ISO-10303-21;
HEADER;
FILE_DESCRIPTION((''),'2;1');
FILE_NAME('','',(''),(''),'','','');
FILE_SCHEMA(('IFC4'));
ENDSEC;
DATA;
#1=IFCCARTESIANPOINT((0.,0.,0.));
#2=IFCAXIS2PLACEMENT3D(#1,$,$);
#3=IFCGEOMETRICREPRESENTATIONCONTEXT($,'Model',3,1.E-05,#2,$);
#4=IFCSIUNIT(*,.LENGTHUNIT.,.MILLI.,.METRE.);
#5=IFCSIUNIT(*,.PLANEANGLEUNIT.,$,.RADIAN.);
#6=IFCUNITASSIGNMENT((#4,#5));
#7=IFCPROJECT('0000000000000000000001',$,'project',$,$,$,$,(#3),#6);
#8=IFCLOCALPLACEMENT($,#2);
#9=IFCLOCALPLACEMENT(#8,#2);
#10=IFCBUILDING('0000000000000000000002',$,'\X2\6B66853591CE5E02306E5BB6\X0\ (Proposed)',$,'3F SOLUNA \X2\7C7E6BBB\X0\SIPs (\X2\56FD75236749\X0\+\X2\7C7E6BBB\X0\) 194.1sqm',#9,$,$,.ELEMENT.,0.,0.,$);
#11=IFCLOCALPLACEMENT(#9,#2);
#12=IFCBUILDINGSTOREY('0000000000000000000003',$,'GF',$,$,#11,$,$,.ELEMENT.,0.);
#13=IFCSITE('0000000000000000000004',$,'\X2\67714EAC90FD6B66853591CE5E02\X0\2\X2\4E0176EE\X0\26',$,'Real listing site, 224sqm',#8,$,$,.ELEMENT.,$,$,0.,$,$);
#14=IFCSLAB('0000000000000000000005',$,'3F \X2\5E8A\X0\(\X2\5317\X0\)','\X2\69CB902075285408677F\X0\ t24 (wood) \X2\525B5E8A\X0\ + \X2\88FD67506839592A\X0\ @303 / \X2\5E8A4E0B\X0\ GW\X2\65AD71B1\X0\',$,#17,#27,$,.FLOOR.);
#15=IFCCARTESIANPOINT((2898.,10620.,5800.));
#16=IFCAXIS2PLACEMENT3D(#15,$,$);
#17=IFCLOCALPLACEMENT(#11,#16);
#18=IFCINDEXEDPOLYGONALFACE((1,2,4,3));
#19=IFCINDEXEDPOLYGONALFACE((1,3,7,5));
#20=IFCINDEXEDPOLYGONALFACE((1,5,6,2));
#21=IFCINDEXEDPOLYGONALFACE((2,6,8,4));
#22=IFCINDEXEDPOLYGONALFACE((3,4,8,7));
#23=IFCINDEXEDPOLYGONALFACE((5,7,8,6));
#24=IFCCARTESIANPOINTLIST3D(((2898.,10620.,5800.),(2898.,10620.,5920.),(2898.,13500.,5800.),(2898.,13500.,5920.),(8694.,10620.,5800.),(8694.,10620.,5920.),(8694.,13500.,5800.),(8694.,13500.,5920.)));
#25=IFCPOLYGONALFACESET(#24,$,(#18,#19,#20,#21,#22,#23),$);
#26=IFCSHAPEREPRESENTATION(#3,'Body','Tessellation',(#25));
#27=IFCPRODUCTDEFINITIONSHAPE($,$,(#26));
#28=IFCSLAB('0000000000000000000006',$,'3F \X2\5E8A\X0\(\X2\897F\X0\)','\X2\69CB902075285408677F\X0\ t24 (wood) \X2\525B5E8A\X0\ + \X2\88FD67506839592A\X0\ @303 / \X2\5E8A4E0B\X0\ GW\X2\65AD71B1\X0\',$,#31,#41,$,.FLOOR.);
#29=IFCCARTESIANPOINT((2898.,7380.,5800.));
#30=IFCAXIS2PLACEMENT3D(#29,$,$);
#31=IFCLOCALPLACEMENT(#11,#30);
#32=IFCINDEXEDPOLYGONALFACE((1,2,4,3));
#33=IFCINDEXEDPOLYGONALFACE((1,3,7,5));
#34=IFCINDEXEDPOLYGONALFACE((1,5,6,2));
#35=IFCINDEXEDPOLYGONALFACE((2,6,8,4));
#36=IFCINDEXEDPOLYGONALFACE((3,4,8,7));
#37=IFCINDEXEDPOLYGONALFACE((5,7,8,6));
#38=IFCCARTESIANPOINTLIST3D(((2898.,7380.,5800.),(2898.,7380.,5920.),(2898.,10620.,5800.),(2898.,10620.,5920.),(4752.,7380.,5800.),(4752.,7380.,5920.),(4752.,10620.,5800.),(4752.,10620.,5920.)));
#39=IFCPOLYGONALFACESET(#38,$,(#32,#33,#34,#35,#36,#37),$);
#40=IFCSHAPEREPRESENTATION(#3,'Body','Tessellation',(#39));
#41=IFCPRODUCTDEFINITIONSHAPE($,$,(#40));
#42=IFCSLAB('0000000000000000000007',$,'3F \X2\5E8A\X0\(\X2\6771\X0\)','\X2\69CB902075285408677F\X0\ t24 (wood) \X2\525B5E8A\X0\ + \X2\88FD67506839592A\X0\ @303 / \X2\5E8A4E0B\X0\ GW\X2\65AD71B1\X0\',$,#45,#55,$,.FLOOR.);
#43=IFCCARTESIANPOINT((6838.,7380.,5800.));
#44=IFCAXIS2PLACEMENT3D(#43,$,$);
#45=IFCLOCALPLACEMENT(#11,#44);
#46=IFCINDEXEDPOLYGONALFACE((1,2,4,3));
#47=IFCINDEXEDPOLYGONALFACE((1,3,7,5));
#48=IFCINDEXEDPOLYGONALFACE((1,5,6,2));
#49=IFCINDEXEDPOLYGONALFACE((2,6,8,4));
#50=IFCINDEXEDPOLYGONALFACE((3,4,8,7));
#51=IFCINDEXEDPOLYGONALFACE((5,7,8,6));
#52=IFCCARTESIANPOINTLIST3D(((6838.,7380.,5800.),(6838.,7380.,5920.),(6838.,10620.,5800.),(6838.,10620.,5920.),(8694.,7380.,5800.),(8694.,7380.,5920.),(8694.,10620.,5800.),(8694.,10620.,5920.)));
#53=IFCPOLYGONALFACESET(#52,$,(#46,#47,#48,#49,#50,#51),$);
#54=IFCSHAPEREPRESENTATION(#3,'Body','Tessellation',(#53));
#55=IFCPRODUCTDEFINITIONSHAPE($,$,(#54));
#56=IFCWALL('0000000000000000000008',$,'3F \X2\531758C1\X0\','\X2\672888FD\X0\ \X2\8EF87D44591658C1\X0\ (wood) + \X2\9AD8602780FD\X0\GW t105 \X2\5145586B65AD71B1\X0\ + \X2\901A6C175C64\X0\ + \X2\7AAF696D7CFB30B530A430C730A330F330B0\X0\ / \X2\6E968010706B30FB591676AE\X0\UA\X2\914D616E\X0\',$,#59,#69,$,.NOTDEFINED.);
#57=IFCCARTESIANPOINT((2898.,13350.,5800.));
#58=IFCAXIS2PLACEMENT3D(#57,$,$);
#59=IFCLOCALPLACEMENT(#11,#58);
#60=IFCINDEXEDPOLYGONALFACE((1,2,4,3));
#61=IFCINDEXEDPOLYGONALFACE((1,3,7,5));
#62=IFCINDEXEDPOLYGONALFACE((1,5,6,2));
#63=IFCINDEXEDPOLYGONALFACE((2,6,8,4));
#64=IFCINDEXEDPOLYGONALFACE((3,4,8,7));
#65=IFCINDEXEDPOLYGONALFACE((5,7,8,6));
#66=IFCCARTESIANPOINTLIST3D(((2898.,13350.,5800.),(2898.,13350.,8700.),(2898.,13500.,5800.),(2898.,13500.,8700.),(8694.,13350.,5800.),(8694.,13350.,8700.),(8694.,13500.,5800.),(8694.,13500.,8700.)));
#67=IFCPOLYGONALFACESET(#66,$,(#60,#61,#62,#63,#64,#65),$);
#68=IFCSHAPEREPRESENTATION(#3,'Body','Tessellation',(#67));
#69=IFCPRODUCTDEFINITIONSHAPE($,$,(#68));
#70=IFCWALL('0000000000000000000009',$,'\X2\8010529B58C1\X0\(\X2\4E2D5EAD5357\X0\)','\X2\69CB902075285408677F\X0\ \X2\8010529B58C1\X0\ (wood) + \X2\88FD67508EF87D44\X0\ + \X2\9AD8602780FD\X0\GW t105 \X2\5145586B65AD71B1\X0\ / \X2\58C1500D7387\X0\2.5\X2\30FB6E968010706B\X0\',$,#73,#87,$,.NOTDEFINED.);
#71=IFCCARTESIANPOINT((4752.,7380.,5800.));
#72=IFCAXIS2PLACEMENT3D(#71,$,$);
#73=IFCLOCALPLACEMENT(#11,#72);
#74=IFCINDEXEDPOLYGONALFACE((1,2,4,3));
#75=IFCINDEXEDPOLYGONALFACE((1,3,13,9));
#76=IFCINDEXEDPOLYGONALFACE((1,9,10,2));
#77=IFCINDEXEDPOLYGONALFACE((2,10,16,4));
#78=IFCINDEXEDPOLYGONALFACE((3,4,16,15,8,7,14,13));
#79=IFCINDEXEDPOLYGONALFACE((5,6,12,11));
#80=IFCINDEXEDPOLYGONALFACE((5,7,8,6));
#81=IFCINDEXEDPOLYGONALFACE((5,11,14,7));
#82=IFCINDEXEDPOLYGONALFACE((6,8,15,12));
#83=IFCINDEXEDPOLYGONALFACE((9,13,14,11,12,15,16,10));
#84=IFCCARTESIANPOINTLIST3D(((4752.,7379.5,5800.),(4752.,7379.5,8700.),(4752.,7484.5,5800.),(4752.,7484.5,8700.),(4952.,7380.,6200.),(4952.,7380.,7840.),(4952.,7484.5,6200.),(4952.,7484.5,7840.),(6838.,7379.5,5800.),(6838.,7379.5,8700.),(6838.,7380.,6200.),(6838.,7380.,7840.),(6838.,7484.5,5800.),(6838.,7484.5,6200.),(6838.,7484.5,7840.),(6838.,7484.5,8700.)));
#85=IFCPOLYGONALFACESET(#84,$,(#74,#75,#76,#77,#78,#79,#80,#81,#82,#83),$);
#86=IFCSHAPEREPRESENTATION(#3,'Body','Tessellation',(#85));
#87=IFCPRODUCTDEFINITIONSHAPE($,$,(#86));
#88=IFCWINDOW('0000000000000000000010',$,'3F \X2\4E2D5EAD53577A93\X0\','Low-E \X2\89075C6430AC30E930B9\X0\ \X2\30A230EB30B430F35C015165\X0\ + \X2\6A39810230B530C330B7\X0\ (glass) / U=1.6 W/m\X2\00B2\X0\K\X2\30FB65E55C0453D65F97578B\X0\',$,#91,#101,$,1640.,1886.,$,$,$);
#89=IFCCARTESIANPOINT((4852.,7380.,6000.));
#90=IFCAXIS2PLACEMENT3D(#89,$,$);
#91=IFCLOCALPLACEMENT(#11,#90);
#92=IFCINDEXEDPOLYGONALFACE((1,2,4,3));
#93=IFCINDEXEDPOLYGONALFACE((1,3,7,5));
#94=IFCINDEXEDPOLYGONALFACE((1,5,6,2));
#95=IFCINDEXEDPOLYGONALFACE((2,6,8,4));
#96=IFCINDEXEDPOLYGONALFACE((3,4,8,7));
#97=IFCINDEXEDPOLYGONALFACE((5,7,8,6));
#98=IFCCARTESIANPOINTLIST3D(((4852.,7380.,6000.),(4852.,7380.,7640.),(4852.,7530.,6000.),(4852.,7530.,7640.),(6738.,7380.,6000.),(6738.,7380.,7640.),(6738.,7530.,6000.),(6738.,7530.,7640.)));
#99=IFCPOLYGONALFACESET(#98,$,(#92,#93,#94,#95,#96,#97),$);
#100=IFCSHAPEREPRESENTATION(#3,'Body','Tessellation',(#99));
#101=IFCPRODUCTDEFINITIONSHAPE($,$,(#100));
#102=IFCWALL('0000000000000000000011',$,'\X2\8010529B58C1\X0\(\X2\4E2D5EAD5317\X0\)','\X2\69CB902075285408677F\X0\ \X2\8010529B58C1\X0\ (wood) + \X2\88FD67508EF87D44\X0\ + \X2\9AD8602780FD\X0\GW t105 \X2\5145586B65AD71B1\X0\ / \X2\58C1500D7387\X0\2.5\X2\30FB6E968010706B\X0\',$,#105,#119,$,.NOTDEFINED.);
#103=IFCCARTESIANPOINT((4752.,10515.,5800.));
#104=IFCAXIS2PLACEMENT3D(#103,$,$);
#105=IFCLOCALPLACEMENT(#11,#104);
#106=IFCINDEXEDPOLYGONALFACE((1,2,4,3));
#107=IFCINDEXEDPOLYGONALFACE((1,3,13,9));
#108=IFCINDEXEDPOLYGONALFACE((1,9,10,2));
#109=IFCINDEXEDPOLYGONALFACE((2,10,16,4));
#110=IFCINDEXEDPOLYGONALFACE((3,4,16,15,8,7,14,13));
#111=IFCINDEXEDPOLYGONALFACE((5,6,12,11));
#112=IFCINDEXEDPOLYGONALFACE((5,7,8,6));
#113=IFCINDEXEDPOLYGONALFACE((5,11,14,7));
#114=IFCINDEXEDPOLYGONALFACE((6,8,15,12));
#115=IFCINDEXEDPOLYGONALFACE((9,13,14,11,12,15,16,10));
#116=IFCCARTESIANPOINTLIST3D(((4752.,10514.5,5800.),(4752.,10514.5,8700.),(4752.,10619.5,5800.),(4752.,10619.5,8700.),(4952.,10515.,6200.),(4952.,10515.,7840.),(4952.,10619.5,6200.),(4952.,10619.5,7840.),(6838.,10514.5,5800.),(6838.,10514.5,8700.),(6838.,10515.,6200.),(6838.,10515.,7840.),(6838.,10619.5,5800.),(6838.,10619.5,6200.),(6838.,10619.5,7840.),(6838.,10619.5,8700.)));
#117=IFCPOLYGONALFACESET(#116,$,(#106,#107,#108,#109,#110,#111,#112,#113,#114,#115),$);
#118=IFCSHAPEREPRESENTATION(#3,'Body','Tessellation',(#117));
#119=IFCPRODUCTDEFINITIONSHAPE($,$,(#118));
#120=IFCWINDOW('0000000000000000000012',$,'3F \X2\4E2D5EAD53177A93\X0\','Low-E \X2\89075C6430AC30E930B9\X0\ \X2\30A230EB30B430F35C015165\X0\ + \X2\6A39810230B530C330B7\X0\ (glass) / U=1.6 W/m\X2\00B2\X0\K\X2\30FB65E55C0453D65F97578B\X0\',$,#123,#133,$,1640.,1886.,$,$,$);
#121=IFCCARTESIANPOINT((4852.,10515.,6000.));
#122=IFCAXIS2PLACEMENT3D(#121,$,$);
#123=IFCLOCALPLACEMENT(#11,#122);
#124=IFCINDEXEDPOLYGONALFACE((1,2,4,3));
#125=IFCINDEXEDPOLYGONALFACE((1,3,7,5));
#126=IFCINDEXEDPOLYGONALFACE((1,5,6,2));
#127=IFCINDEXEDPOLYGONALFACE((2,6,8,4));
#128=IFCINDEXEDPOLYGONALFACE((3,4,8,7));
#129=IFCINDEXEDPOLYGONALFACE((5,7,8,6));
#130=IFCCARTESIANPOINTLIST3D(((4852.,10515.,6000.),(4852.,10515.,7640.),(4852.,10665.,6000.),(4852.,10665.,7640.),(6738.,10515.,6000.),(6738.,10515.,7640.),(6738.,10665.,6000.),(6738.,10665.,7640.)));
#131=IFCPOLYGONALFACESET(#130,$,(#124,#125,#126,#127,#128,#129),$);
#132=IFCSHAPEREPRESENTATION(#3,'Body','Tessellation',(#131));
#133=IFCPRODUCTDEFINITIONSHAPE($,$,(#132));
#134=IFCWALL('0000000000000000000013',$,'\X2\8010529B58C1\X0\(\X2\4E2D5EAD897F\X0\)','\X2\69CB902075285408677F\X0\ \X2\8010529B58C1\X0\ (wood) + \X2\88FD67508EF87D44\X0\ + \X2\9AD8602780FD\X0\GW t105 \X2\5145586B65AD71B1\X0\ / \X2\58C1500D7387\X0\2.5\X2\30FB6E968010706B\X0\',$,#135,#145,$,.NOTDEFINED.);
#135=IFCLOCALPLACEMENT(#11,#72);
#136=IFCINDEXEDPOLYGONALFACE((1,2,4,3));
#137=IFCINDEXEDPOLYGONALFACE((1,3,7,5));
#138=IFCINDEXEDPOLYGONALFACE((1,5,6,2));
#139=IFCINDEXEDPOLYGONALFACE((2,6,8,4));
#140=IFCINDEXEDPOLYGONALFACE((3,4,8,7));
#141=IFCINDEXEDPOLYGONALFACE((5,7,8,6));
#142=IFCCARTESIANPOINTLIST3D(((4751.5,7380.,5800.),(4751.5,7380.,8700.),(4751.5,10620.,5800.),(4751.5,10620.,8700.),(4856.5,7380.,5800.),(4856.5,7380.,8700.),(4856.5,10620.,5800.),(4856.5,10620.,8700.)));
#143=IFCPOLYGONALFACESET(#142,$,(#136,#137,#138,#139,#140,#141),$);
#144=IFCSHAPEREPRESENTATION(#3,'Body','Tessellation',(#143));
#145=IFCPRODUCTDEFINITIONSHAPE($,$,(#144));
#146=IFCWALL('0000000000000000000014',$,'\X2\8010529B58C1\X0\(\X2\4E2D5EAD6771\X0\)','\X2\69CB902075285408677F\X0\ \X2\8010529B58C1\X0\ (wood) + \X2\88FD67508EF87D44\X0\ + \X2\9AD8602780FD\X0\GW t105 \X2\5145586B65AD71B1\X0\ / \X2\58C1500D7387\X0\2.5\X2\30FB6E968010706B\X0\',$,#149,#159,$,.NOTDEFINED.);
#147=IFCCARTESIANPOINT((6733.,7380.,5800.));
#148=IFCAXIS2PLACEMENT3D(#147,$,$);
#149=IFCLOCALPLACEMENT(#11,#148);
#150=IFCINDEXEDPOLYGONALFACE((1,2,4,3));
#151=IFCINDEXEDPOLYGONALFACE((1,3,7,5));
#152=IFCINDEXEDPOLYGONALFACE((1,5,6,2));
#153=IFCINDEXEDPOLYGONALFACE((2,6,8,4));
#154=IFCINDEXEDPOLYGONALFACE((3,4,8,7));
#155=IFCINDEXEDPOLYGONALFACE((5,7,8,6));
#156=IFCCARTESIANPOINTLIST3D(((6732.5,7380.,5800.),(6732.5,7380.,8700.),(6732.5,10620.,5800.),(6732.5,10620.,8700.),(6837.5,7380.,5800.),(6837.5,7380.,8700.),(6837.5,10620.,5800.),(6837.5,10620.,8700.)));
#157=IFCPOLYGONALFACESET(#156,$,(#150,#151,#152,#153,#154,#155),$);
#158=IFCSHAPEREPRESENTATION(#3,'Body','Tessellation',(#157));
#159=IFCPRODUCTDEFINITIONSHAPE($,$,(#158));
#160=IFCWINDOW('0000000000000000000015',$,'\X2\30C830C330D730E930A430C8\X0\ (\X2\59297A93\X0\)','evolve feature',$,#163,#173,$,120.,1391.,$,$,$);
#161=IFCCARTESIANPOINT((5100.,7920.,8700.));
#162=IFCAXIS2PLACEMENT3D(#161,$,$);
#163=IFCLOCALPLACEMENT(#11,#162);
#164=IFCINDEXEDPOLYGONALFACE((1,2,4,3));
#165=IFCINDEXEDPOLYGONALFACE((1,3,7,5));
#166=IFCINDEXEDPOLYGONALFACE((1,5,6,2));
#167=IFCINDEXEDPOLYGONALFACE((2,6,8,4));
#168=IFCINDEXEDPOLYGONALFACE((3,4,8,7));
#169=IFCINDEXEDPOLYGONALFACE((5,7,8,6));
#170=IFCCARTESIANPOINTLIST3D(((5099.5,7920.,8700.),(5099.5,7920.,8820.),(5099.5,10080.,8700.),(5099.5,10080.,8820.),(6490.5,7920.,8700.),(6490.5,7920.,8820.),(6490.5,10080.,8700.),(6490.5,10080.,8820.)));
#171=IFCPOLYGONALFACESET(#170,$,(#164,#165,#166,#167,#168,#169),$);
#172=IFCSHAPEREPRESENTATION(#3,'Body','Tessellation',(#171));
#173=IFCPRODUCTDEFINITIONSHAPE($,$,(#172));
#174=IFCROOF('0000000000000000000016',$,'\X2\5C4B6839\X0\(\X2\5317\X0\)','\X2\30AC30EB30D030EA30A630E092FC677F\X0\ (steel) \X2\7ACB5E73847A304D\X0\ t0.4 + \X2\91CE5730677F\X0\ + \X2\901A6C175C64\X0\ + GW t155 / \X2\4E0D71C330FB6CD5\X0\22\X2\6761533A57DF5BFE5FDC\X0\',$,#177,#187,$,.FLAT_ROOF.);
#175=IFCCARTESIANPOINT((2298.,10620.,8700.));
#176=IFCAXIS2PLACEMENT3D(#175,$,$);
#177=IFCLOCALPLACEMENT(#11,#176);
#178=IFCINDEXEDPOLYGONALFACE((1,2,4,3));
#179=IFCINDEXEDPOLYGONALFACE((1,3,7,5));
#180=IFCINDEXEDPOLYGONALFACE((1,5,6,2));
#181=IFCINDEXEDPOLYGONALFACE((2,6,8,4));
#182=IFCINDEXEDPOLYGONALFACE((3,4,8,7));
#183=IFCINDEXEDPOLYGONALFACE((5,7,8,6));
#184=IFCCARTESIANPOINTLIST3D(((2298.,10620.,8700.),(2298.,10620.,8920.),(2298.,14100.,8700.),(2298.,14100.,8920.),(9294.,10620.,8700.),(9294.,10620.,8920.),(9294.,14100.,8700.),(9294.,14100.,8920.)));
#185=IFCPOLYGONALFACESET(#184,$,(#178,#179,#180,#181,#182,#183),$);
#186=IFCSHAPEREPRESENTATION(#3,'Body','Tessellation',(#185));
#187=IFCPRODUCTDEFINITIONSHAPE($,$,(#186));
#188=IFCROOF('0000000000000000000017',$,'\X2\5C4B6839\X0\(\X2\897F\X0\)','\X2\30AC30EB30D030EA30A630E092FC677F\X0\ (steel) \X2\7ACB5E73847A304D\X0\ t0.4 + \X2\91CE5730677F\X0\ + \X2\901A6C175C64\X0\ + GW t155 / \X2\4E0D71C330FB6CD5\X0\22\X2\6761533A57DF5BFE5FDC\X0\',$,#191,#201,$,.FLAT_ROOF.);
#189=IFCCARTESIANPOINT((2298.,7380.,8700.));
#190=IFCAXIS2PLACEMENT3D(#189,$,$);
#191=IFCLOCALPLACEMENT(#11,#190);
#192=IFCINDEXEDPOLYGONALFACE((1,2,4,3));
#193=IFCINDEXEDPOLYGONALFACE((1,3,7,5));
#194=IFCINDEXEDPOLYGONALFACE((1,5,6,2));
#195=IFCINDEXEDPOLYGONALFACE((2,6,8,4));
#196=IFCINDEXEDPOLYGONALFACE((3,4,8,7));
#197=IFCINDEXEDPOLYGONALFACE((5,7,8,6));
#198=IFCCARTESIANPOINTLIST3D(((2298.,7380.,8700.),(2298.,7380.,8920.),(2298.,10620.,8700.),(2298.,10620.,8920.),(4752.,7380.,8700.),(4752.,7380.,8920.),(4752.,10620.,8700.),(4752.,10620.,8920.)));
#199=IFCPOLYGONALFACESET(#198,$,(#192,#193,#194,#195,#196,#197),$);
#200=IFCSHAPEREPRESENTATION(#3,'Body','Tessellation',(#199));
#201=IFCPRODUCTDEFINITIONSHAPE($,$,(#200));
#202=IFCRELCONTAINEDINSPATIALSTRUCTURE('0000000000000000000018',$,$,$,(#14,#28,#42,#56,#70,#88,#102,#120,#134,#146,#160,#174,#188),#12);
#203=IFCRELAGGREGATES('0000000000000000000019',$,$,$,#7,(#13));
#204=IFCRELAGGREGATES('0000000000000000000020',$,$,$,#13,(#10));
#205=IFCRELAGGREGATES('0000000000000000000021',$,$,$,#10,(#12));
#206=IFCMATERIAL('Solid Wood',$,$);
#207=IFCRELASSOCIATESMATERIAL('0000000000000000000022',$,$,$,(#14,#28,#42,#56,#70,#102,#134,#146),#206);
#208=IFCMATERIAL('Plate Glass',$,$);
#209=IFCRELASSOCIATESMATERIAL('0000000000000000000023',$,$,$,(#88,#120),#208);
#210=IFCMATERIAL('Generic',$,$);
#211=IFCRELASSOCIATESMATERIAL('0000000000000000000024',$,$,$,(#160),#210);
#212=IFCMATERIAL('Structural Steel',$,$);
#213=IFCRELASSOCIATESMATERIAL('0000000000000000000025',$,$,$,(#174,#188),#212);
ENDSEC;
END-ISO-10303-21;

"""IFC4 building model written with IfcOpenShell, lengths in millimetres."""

from ifc_helpers import new_model, si_unit, frame, frame_2d, origin, place, context, project, spatial, rectangle, extrude, material, element, fill, save


model = new_model("IFC4")

# Units and contexts
model_context = context("Model", 3, precision=1e-05, world=origin())
ifc_project = project(units=[si_unit("LENGTHUNIT", "METRE", prefix="MILLI"), si_unit("PLANEANGLEUNIT", "RADIAN")], contexts=[model_context])

# Site, building, storey
site_placement = place(None, origin())
site = spatial("IfcSite", under=ifc_project, at=site_placement, Name="東京都武蔵野市2丁目26", ObjectType="Real listing site, 224sqm", CompositionType="ELEMENT", RefElevation=0.0)
building_placement = place(site_placement, origin())
building = spatial("IfcBuilding", under=site, at=building_placement, Name="武蔵野市の家 (Proposed)", ObjectType="3F SOLUNA 籾殻SIPs (国産杉+籾殻) 194.1sqm", CompositionType="ELEMENT", ElevationOfRefHeight=0.0, ElevationOfTerrain=0.0)
storey_placement = place(building_placement, origin())
storey = spatial("IfcBuildingStorey", under=building, at=storey_placement, Name="GF", CompositionType="ELEMENT", Elevation=0.0)

# Slabs
ifc_material_1 = material(Name="Solid Wood")
slab_1_placement = place(storey_placement, frame((2898.0, 10620.0, 5800.0)))
element("IfcSlab", 1, at=slab_1_placement, inside=storey, material=ifc_material_1, Name="3F 床(北)", Description="構造用合板 t24 (wood) 剛床 + 製材根太 @303 / 床下 GW断熱", PredefinedType="FLOOR", context=model_context, shape_type="SweptSolid", body=[
    extrude(rectangle(XDim=5796.0, YDim=2880.0, at=frame_2d((2898.0, 1440.0))), frame((2898.0, 10620.0, 5800.0)), (0.0, 0.0, 1.0), 120.0),
])
slab_2_placement = place(storey_placement, frame((2898.0, 7380.0, 5800.0)))
element("IfcSlab", 2, at=slab_2_placement, inside=storey, material=ifc_material_1, Name="3F 床(西)", Description="構造用合板 t24 (wood) 剛床 + 製材根太 @303 / 床下 GW断熱", PredefinedType="FLOOR", context=model_context, shape_type="SweptSolid", body=[
    extrude(rectangle(XDim=1854.0, YDim=3240.0, at=frame_2d((927.0, 1620.0))), frame((2898.0, 7380.0, 5800.0)), (0.0, 0.0, 1.0), 120.0),
])
slab_3_placement = place(storey_placement, frame((6838.0, 7380.0, 5800.0)))
element("IfcSlab", 3, at=slab_3_placement, inside=storey, material=ifc_material_1, Name="3F 床(東)", Description="構造用合板 t24 (wood) 剛床 + 製材根太 @303 / 床下 GW断熱", PredefinedType="FLOOR", context=model_context, shape_type="SweptSolid", body=[
    extrude(rectangle(XDim=1856.0, YDim=3240.0, at=frame_2d((928.0, 1620.0))), frame((6838.0, 7380.0, 5800.0)), (0.0, 0.0, 1.0), 120.0),
])

# Wall
wall_1_placement = place(storey_placement, frame((2898.0, 13350.0, 5800.0)))
element("IfcWall", 4, at=wall_1_placement, inside=storey, material=ifc_material_1, Name="3F 北壁", Description="木製 軸組外壁 (wood) + 高性能GW t105 充填断熱 + 通気層 + 窯業系サイディング / 準耐火・外皮UA配慮", PredefinedType="NOTDEFINED", context=model_context, shape_type="SweptSolid", body=[
    extrude(rectangle(XDim=5796.0, YDim=150.0, at=frame_2d((2898.0, 75.0))), frame((2898.0, 13350.0, 5800.0)), (0.0, 0.0, 1.0), 2900.0),
])

# Walls, openings, windows
wall_2_placement = place(storey_placement, frame((4752.0, 7380.0, 5800.0)))
wall_2 = element("IfcWall", 5, at=wall_2_placement, inside=storey, material=ifc_material_1, Name="耐力壁(中庭南)", Description="構造用合板 耐力壁 (wood) + 製材軸組 + 高性能GW t105 充填断熱 / 壁倍率2.5・準耐火", PredefinedType="NOTDEFINED", context=model_context, shape_type="SweptSolid", body=[
    extrude(rectangle(XDim=2086.0, YDim=105.0, at=frame_2d((1043.0, 52.0))), frame((4752.0, 7380.0, 5800.0)), (0.0, 0.0, 1.0), 2900.0),
])
opening_1_placement = place(storey_placement, frame((4852.0, 7380.0, 6000.0)))
opening_1 = element("IfcOpeningElement", 6, at=opening_1_placement, cuts=wall_2, PredefinedType="NOTDEFINED", context=model_context, shape_type="SweptSolid", body=[
    extrude(rectangle(XDim=1886.0, YDim=150.0, at=frame_2d((943.0, 75.0))), frame((4852.0, 7380.0, 6000.0)), (0.0, 0.0, 1.0), 1640.0),
])
ifc_material_2 = material(Name="Plate Glass")
window_1_placement = place(storey_placement, frame((4852.0, 7380.0, 6000.0)))
window_1 = element("IfcWindow", 7, at=window_1_placement, inside=storey, material=ifc_material_2, Name="3F 中庭南窓", Description="Low-E 複層ガラス アルゴン封入 + 樹脂サッシ (glass) / U=1.6 W/m²K・日射取得型", OverallHeight=1640.0, OverallWidth=1886.0, context=model_context, shape_type="SweptSolid", body=[
    extrude(rectangle(XDim=1886.0, YDim=150.0, at=frame_2d((943.0, 75.0))), frame((4852.0, 7380.0, 6000.0)), (0.0, 0.0, 1.0), 1640.0),
])
fill(opening_1, window_1)
wall_3_placement = place(storey_placement, frame((4752.0, 10515.0, 5800.0)))
wall_3 = element("IfcWall", 8, at=wall_3_placement, inside=storey, material=ifc_material_1, Name="耐力壁(中庭北)", Description="構造用合板 耐力壁 (wood) + 製材軸組 + 高性能GW t105 充填断熱 / 壁倍率2.5・準耐火", PredefinedType="NOTDEFINED", context=model_context, shape_type="SweptSolid", body=[
    extrude(rectangle(XDim=2086.0, YDim=105.0, at=frame_2d((1043.0, 52.0))), frame((4752.0, 10515.0, 5800.0)), (0.0, 0.0, 1.0), 2900.0),
])
opening_2_placement = place(storey_placement, frame((4852.0, 10515.0, 6000.0)))
opening_2 = element("IfcOpeningElement", 9, at=opening_2_placement, cuts=wall_3, PredefinedType="NOTDEFINED", context=model_context, shape_type="SweptSolid", body=[
    extrude(rectangle(XDim=1886.0, YDim=150.0, at=frame_2d((943.0, 75.0))), frame((4852.0, 10515.0, 6000.0)), (0.0, 0.0, 1.0), 1640.0),
])
window_2_placement = place(storey_placement, frame((4852.0, 10515.0, 6000.0)))
window_2 = element("IfcWindow", 10, at=window_2_placement, inside=storey, material=ifc_material_2, Name="3F 中庭北窓", Description="Low-E 複層ガラス アルゴン封入 + 樹脂サッシ (glass) / U=1.6 W/m²K・日射取得型", OverallHeight=1640.0, OverallWidth=1886.0, context=model_context, shape_type="SweptSolid", body=[
    extrude(rectangle(XDim=1886.0, YDim=150.0, at=frame_2d((943.0, 75.0))), frame((4852.0, 10515.0, 6000.0)), (0.0, 0.0, 1.0), 1640.0),
])
fill(opening_2, window_2)

# Walls
wall_4_placement = place(storey_placement, frame((4752.0, 7380.0, 5800.0)))
element("IfcWall", 11, at=wall_4_placement, inside=storey, material=ifc_material_1, Name="耐力壁(中庭西)", Description="構造用合板 耐力壁 (wood) + 製材軸組 + 高性能GW t105 充填断熱 / 壁倍率2.5・準耐火", PredefinedType="NOTDEFINED", context=model_context, shape_type="SweptSolid", body=[
    extrude(rectangle(XDim=105.0, YDim=3240.0, at=frame_2d((52.0, 1620.0))), frame((4752.0, 7380.0, 5800.0)), (0.0, 0.0, 1.0), 2900.0),
])
wall_5_placement = place(storey_placement, frame((6733.0, 7380.0, 5800.0)))
element("IfcWall", 12, at=wall_5_placement, inside=storey, material=ifc_material_1, Name="耐力壁(中庭東)", Description="構造用合板 耐力壁 (wood) + 製材軸組 + 高性能GW t105 充填断熱 / 壁倍率2.5・準耐火", PredefinedType="NOTDEFINED", context=model_context, shape_type="SweptSolid", body=[
    extrude(rectangle(XDim=105.0, YDim=3240.0, at=frame_2d((52.0, 1620.0))), frame((6733.0, 7380.0, 5800.0)), (0.0, 0.0, 1.0), 2900.0),
])

# Window
ifc_material_3 = material(Name="Generic")
window_3_placement = place(storey_placement, frame((5100.0, 7920.0, 8700.0)))
element("IfcWindow", 13, at=window_3_placement, inside=storey, material=ifc_material_3, Name="トップライト (天窓)", Description="evolve feature", OverallHeight=120.0, OverallWidth=1391.0, context=model_context, shape_type="SweptSolid", body=[
    extrude(rectangle(XDim=1391.0, YDim=2160.0, at=frame_2d((695.0, 1080.0))), frame((5100.0, 7920.0, 8700.0)), (0.0, 0.0, 1.0), 120.0),
])

# Roofs
ifc_material_4 = material(Name="Structural Steel")
for number, where, name in (
    (14, (2298.0, 10620.0, 8700.0), "屋根(北)"),
):
    element("IfcRoof", number, at=place(storey_placement, frame(where)), inside=storey, material=ifc_material_4, Name=name, Description="ガルバリウム鋼板 (steel) 立平葺き t0.4 + 野地板 + 通気層 + GW t155 / 不燃・法22条区域対応", PredefinedType="FLAT_ROOF", context=model_context, shape_type="SweptSolid", body=[
        extrude(rectangle(XDim=6996.0, YDim=3480.0, at=frame_2d((3498.0, 1740.0))), frame((2298.0, 10620.0, 8700.0)), (0.0, 0.0, 1.0), 220.0),
    ])
roof_1_placement = place(storey_placement, frame((2298.0, 7380.0, 8700.0)))
element("IfcRoof", 15, at=roof_1_placement, inside=storey, material=ifc_material_4, Name="屋根(西)", Description="ガルバリウム鋼板 (steel) 立平葺き t0.4 + 野地板 + 通気層 + GW t155 / 不燃・法22条区域対応", PredefinedType="FLAT_ROOF", context=model_context, shape_type="SweptSolid", body=[
    extrude(rectangle(XDim=2454.0, YDim=3240.0, at=frame_2d((1227.0, 1620.0))), frame((2298.0, 7380.0, 8700.0)), (0.0, 0.0, 1.0), 220.0),
])

save(model, "model.ifc")
